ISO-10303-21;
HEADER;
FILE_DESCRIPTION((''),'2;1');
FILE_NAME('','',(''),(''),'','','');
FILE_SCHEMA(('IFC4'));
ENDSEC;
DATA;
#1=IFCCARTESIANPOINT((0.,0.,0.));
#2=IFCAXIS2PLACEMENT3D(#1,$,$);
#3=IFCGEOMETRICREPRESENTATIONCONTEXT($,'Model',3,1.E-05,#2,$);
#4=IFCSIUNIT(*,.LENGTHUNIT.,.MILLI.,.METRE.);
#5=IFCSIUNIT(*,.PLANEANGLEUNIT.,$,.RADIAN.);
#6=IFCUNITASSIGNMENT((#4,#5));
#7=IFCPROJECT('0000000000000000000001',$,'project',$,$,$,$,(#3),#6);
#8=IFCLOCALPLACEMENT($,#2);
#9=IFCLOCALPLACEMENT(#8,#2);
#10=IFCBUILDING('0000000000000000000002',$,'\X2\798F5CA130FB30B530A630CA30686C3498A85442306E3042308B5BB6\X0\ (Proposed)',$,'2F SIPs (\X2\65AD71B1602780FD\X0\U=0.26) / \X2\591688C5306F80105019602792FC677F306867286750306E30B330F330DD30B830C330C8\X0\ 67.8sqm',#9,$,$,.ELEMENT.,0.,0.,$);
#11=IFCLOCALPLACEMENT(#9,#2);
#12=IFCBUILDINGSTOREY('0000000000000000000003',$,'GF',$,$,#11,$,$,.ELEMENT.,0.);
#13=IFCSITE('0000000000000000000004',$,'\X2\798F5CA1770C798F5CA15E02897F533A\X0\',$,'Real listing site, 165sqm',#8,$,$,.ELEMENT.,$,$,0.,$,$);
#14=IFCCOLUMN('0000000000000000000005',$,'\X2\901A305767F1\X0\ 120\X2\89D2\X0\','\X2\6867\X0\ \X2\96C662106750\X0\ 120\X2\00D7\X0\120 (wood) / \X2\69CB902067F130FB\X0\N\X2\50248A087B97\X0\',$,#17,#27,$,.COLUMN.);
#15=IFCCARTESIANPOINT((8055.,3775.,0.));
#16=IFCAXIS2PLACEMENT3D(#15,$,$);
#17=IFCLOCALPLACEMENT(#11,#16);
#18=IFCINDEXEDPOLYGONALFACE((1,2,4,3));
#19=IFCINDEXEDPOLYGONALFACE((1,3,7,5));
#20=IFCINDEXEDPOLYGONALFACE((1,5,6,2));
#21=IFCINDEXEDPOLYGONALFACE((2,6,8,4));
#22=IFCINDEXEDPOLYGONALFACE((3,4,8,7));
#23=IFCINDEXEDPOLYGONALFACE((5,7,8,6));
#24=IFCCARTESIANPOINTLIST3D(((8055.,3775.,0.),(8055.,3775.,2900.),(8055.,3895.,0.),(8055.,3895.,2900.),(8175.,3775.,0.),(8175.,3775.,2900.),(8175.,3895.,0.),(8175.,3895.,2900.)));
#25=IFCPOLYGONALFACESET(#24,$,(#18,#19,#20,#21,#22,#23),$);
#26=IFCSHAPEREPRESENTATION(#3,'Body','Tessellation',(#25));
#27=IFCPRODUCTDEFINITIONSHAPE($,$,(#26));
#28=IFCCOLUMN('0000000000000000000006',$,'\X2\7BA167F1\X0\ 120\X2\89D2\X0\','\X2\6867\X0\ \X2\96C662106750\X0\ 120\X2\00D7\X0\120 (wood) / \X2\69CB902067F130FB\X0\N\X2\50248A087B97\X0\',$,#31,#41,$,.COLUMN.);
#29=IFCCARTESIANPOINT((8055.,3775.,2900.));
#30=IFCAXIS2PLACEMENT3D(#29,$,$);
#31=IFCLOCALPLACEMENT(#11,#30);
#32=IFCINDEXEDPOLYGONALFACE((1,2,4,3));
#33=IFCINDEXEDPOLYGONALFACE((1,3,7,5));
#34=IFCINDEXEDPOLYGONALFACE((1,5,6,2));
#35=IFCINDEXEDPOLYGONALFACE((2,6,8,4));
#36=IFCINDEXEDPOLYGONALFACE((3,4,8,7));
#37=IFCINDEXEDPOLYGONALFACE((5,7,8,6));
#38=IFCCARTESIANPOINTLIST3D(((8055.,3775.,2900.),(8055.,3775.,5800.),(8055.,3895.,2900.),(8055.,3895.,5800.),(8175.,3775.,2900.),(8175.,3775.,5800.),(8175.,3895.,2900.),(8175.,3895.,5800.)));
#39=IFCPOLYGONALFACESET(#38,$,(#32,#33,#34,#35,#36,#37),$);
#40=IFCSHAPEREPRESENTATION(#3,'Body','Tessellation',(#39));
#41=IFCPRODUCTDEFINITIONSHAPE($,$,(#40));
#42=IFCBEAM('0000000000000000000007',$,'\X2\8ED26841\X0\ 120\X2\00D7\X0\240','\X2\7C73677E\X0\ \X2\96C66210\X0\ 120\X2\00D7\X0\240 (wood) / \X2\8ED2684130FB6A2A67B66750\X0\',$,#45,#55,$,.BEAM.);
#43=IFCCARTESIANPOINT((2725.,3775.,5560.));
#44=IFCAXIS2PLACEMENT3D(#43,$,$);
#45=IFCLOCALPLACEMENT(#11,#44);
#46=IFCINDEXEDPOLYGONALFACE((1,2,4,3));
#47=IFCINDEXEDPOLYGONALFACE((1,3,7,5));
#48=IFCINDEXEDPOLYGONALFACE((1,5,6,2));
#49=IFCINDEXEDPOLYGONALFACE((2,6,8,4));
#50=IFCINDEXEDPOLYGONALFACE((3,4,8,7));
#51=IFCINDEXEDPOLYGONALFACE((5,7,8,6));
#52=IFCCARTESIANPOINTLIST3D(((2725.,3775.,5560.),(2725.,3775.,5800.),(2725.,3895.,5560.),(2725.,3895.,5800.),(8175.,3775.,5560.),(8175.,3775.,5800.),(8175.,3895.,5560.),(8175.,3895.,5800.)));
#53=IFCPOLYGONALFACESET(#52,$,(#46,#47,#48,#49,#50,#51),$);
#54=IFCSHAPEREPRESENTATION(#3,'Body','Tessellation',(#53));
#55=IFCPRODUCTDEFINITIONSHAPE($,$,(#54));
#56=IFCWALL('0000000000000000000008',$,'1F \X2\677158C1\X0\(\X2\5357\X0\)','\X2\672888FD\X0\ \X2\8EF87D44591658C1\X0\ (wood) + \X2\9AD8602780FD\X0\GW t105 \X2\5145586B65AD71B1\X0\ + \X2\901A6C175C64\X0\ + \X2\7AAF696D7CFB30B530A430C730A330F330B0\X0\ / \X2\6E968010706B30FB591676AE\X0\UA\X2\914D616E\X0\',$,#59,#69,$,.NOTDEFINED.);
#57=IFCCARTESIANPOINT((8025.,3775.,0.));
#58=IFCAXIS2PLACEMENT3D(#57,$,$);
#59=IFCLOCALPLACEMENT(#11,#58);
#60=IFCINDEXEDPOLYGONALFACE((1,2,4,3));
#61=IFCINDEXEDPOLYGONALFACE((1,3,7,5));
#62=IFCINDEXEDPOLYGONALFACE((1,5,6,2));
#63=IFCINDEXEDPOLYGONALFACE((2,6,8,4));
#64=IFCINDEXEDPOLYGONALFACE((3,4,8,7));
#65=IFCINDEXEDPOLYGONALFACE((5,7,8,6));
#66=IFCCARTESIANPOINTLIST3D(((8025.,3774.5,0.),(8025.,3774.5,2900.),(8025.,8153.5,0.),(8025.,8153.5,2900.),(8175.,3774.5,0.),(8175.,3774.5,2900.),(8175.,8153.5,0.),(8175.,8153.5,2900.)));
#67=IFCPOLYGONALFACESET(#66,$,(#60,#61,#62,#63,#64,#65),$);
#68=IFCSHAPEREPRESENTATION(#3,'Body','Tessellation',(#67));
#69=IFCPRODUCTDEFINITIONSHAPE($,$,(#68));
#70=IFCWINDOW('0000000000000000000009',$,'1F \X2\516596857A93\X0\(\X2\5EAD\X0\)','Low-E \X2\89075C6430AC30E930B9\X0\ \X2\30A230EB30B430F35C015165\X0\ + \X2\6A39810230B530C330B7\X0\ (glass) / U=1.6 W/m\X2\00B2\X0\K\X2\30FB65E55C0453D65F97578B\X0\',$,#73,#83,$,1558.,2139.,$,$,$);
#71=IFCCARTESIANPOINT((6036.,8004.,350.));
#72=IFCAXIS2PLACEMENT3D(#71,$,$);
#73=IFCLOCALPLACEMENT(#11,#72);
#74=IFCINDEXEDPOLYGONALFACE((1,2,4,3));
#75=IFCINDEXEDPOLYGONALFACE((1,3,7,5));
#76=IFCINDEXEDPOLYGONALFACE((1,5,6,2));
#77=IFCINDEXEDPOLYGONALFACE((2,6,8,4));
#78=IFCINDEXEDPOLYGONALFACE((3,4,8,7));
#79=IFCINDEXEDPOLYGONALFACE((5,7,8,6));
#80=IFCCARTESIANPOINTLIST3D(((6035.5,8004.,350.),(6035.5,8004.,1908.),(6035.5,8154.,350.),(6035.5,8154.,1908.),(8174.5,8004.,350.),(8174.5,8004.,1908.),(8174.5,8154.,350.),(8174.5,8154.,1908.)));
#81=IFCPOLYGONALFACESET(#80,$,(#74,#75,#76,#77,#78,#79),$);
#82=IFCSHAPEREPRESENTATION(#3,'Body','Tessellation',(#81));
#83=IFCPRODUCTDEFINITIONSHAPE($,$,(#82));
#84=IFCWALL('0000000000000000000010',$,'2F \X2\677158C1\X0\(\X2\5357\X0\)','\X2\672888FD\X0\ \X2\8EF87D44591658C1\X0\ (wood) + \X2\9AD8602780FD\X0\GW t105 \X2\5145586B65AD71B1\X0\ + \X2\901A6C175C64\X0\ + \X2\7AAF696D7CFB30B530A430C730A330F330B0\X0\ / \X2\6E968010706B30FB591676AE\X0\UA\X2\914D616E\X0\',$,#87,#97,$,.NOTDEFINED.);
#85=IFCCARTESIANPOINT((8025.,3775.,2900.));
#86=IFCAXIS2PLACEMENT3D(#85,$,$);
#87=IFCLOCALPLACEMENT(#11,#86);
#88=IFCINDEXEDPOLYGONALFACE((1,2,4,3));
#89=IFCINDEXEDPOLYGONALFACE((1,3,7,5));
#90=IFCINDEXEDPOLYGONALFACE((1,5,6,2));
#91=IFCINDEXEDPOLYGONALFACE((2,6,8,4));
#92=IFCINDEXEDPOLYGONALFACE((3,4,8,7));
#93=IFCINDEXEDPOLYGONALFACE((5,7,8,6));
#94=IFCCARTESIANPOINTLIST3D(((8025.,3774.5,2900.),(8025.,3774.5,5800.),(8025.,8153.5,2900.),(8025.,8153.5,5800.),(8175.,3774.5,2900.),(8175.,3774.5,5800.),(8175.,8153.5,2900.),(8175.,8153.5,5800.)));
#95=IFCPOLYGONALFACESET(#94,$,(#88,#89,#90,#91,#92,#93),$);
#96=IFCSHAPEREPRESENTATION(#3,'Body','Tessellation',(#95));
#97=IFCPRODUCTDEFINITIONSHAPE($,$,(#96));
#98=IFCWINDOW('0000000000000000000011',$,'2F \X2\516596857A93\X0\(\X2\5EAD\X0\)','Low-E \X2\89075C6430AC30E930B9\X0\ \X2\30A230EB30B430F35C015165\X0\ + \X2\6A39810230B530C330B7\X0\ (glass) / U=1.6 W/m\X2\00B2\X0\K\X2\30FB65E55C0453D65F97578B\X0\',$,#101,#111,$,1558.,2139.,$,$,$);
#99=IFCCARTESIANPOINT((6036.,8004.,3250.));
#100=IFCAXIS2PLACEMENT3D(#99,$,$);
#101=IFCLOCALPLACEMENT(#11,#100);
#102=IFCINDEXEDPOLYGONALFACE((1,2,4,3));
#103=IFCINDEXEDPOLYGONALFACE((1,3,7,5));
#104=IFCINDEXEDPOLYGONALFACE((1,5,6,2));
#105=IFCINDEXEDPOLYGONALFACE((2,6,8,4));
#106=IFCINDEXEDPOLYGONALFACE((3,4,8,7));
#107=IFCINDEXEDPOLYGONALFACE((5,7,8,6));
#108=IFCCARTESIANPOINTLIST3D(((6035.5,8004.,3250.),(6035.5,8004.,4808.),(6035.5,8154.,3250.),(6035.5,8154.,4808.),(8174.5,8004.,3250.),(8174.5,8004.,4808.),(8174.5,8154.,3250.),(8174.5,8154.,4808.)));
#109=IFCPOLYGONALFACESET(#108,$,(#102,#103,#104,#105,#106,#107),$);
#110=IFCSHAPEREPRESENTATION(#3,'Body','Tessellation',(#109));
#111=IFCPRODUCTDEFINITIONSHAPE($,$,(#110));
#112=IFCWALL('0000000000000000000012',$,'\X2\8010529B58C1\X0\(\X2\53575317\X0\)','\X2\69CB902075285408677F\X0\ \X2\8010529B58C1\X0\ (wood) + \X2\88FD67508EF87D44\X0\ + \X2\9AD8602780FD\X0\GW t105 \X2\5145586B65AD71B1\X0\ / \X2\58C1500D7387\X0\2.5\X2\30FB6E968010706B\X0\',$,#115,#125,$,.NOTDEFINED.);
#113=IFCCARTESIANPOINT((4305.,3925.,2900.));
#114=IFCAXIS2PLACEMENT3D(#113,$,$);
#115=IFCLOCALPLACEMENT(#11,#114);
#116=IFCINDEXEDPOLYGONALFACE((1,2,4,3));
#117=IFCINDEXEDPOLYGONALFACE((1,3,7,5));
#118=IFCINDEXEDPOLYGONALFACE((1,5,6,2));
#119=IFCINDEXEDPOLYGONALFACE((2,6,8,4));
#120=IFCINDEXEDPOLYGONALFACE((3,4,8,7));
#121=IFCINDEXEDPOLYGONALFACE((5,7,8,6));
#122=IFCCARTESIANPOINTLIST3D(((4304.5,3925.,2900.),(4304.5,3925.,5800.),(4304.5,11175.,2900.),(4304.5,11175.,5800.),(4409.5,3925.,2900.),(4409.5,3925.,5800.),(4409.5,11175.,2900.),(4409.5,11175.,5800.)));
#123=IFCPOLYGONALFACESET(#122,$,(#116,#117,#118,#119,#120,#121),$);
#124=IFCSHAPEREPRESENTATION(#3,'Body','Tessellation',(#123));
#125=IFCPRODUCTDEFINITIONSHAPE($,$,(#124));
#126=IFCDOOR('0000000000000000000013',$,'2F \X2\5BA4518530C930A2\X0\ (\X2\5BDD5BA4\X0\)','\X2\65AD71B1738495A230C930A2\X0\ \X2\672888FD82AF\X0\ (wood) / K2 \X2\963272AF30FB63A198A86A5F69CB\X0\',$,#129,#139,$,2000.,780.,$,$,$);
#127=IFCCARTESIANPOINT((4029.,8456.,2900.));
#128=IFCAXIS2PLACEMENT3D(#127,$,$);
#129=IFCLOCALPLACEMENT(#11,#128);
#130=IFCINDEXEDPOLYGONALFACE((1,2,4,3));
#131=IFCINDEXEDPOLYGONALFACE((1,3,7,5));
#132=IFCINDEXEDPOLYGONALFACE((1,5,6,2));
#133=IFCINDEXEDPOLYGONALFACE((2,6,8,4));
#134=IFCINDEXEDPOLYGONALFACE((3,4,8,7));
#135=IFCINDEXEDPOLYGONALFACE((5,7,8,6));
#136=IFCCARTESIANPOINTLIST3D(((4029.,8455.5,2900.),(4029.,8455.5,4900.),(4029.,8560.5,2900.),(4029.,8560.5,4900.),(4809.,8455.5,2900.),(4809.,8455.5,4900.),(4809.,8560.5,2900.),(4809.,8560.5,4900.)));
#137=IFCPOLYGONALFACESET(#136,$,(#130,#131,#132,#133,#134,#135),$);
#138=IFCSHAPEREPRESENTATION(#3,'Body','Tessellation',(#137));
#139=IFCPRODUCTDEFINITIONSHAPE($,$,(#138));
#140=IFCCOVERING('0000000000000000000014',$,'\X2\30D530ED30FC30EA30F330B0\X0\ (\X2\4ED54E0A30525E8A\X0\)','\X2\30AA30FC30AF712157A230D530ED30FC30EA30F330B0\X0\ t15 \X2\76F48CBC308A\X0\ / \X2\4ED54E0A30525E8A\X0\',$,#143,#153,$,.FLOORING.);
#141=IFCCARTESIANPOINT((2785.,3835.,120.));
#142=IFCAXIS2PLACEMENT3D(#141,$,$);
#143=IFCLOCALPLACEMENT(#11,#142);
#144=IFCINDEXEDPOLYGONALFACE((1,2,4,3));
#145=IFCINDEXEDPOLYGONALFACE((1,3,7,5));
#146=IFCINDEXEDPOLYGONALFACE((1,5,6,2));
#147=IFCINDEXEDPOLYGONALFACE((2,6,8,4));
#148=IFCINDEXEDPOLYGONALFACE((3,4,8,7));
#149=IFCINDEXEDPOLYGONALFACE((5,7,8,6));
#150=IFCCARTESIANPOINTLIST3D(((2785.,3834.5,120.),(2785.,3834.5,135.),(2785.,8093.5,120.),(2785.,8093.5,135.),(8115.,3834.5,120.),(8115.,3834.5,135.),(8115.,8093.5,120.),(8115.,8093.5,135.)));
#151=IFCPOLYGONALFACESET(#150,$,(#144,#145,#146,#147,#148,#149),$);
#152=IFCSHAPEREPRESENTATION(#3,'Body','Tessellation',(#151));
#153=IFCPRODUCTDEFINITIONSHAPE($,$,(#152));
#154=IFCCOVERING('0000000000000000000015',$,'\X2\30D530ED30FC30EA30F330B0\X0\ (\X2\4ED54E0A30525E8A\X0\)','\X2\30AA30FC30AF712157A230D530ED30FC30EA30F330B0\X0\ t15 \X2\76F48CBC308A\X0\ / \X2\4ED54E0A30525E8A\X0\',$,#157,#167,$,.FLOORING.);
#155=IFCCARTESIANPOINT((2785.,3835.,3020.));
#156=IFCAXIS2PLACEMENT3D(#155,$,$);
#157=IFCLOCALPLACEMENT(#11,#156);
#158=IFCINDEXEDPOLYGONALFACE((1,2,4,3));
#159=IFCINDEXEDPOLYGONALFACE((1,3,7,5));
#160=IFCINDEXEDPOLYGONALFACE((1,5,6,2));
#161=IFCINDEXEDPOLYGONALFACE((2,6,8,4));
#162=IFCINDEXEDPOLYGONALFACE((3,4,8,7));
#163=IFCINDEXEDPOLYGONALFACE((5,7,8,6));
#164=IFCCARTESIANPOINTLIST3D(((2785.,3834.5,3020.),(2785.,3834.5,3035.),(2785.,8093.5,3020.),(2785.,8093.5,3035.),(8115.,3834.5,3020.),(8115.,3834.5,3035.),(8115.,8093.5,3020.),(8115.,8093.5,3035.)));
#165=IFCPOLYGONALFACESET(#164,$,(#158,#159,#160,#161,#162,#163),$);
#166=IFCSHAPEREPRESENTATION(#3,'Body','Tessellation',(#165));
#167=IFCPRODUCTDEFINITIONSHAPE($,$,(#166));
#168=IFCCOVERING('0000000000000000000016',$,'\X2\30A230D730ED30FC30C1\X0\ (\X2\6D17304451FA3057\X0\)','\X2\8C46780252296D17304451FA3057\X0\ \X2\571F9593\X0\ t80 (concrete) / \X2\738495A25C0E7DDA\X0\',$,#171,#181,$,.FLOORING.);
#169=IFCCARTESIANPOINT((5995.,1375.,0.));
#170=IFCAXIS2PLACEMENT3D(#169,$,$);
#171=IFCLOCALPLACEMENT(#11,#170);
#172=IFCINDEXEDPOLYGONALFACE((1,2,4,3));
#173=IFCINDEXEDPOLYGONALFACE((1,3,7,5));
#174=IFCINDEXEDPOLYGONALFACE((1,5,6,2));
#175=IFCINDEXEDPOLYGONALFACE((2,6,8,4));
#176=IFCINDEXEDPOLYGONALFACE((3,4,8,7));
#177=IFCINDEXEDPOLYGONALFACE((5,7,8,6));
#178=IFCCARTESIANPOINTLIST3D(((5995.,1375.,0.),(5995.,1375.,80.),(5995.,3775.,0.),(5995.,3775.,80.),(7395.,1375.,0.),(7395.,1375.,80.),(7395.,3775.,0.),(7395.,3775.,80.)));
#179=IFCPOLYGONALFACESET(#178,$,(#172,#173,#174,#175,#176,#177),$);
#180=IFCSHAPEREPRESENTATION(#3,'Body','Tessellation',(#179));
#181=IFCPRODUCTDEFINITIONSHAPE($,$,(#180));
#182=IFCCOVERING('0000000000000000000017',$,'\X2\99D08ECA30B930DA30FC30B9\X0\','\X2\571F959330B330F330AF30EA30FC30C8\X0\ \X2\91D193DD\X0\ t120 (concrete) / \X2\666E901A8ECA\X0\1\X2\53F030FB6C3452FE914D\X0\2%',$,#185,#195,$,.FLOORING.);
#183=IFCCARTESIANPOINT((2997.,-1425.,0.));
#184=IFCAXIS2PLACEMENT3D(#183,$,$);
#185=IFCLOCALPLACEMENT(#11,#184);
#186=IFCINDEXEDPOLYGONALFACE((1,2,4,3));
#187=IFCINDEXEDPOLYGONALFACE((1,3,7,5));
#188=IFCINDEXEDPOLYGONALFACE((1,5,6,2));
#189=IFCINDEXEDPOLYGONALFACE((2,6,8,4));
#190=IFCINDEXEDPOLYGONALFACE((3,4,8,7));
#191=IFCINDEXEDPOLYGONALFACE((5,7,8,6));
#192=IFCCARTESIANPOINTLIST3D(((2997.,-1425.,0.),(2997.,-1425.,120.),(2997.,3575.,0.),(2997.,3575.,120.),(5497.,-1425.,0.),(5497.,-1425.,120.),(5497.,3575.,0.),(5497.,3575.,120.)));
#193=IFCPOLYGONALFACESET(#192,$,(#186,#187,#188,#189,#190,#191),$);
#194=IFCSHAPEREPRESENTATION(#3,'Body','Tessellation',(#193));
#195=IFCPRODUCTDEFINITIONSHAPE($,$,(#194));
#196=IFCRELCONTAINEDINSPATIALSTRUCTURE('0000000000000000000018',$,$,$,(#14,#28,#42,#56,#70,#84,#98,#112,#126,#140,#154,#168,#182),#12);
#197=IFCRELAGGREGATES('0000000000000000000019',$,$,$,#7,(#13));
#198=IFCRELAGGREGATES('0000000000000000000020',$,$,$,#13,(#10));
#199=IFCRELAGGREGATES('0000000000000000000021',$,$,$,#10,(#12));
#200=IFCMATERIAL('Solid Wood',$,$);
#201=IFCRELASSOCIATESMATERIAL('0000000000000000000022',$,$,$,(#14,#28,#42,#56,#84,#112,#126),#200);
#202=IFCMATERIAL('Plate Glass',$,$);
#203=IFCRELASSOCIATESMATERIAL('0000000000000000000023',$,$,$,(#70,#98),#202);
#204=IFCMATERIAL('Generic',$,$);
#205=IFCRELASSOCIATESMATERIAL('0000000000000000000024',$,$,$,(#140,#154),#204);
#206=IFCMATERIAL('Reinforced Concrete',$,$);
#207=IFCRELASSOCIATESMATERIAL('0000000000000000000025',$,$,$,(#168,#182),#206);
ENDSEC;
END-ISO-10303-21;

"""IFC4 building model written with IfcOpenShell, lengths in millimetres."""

from ifc_helpers import new_model, si_unit, frame, frame_2d, origin, place, context, project, spatial, rectangle, extrude, material, element, fill, save


model = new_model("IFC4")

# Units and contexts
model_context = context("Model", 3, precision=1e-05, world=origin())
ifc_project = project(units=[si_unit("LENGTHUNIT", "METRE", prefix="MILLI"), si_unit("PLANEANGLEUNIT", "RADIAN")], contexts=[model_context])

# Site, building, storey
site_placement = place(None, origin())
site = spatial("IfcSite", under=ifc_project, at=site_placement, Name="福岡県福岡市西区", ObjectType="Real listing site, 165sqm", CompositionType="ELEMENT", RefElevation=0.0)
building_placement = place(site_placement, origin())
building = spatial("IfcBuilding", under=site, at=building_placement, Name="福岡・サウナと水風呂のある家 (Proposed)", ObjectType="2F SIPs (断熱性能U=0.26) / 外装は耐候性鋼板と木材のコンポジット 67.8sqm", CompositionType="ELEMENT", ElevationOfRefHeight=0.0, ElevationOfTerrain=0.0)
storey_placement = place(building_placement, origin())
storey = spatial("IfcBuildingStorey", under=building, at=storey_placement, Name="GF", CompositionType="ELEMENT", Elevation=0.0)

# Columns
ifc_material_1 = material(Name="Solid Wood")
column_1_placement = place(storey_placement, frame((8055.0, 3775.0, 0.0)))
element("IfcColumn", 1, at=column_1_placement, inside=storey, material=ifc_material_1, Name="通し柱 120角", Description="桧 集成材 120×120 (wood) / 構造柱・N値計算", PredefinedType="COLUMN", context=model_context, shape_type="SweptSolid", body=[
    extrude(rectangle(XDim=120.0, YDim=120.0, at=frame_2d((60.0, 60.0))), frame((8055.0, 3775.0, 0.0)), (0.0, 0.0, 1.0), 2900.0),
])
column_2_placement = place(storey_placement, frame((8055.0, 3775.0, 2900.0)))
element("IfcColumn", 2, at=column_2_placement, inside=storey, material=ifc_material_1, Name="管柱 120角", Description="桧 集成材 120×120 (wood) / 構造柱・N値計算", PredefinedType="COLUMN", context=model_context, shape_type="SweptSolid", body=[
    extrude(rectangle(XDim=120.0, YDim=120.0, at=frame_2d((60.0, 60.0))), frame((8055.0, 3775.0, 2900.0)), (0.0, 0.0, 1.0), 2900.0),
])

# Beam
beam_1_placement = place(storey_placement, frame((2725.0, 3775.0, 5560.0)))
element("IfcBeam", 3, at=beam_1_placement, inside=storey, material=ifc_material_1, Name="軒桁 120×240", Description="米松 集成 120×240 (wood) / 軒桁・横架材", PredefinedType="BEAM", context=model_context, shape_type="SweptSolid", body=[
    extrude(rectangle(XDim=5450.0, YDim=120.0, at=frame_2d((2725.0, 60.0))), frame((2725.0, 3775.0, 5560.0)), (0.0, 0.0, 1.0), 240.0),
])

# Wall, opening, window
wall_1_placement = place(storey_placement, frame((8025.0, 3775.0, 0.0)))
wall_1 = element("IfcWall", 4, at=wall_1_placement, inside=storey, material=ifc_material_1, Name="1F 東壁(南)", Description="木製 軸組外壁 (wood) + 高性能GW t105 充填断熱 + 通気層 + 窯業系サイディング / 準耐火・外皮UA配慮", PredefinedType="NOTDEFINED", context=model_context, shape_type="SweptSolid", body=[
    extrude(rectangle(XDim=150.0, YDim=4379.0, at=frame_2d((75.0, 2189.0))), frame((8025.0, 3775.0, 0.0)), (0.0, 0.0, 1.0), 2900.0),
])
opening_1_placement = place(storey_placement, frame((6036.0, 8004.0, 350.0)))
opening_1 = element("IfcOpeningElement", 5, at=opening_1_placement, cuts=wall_1, PredefinedType="NOTDEFINED", context=model_context, shape_type="SweptSolid", body=[
    extrude(rectangle(XDim=2139.0, YDim=150.0, at=frame_2d((1069.0, 75.0))), frame((6036.0, 8004.0, 350.0)), (0.0, 0.0, 1.0), 1558.0),
])
ifc_material_2 = material(Name="Plate Glass")
window_1_placement = place(storey_placement, frame((6036.0, 8004.0, 350.0)))
window_1 = element("IfcWindow", 6, at=window_1_placement, inside=storey, material=ifc_material_2, Name="1F 入隅窓(庭)", Description="Low-E 複層ガラス アルゴン封入 + 樹脂サッシ (glass) / U=1.6 W/m²K・日射取得型", OverallHeight=1558.0, OverallWidth=2139.0, context=model_context, shape_type="SweptSolid", body=[
    extrude(rectangle(XDim=2139.0, YDim=150.0, at=frame_2d((1069.0, 75.0))), frame((6036.0, 8004.0, 350.0)), (0.0, 0.0, 1.0), 1558.0),
])
fill(opening_1, window_1)

# Wall, opening, window
wall_2_placement = place(storey_placement, frame((8025.0, 3775.0, 2900.0)))
wall_2 = element("IfcWall", 7, at=wall_2_placement, inside=storey, material=ifc_material_1, Name="2F 東壁(南)", Description="木製 軸組外壁 (wood) + 高性能GW t105 充填断熱 + 通気層 + 窯業系サイディング / 準耐火・外皮UA配慮", PredefinedType="NOTDEFINED", context=model_context, shape_type="SweptSolid", body=[
    extrude(rectangle(XDim=150.0, YDim=4379.0, at=frame_2d((75.0, 2189.0))), frame((8025.0, 3775.0, 2900.0)), (0.0, 0.0, 1.0), 2900.0),
])
opening_2_placement = place(storey_placement, frame((6036.0, 8004.0, 3250.0)))
opening_2 = element("IfcOpeningElement", 8, at=opening_2_placement, cuts=wall_2, PredefinedType="NOTDEFINED", context=model_context, shape_type="SweptSolid", body=[
    extrude(rectangle(XDim=2139.0, YDim=150.0, at=frame_2d((1069.0, 75.0))), frame((6036.0, 8004.0, 3250.0)), (0.0, 0.0, 1.0), 1558.0),
])
window_2_placement = place(storey_placement, frame((6036.0, 8004.0, 3250.0)))
window_2 = element("IfcWindow", 9, at=window_2_placement, inside=storey, material=ifc_material_2, Name="2F 入隅窓(庭)", Description="Low-E 複層ガラス アルゴン封入 + 樹脂サッシ (glass) / U=1.6 W/m²K・日射取得型", OverallHeight=1558.0, OverallWidth=2139.0, context=model_context, shape_type="SweptSolid", body=[
    extrude(rectangle(XDim=2139.0, YDim=150.0, at=frame_2d((1069.0, 75.0))), frame((6036.0, 8004.0, 3250.0)), (0.0, 0.0, 1.0), 1558.0),
])
fill(opening_2, window_2)

# Wall, opening, door
wall_3_placement = place(storey_placement, frame((4305.0, 3925.0, 2900.0)))
wall_3 = element("IfcWall", 10, at=wall_3_placement, inside=storey, material=ifc_material_1, Name="耐力壁(南北)", Description="構造用合板 耐力壁 (wood) + 製材軸組 + 高性能GW t105 充填断熱 / 壁倍率2.5・準耐火", PredefinedType="NOTDEFINED", context=model_context, shape_type="SweptSolid", body=[
    extrude(rectangle(XDim=105.0, YDim=7250.0, at=frame_2d((52.0, 3625.0))), frame((4305.0, 3925.0, 2900.0)), (0.0, 0.0, 1.0), 2900.0),
])
opening_3_placement = place(storey_placement, frame((4029.0, 8456.0, 2900.0)))
opening_3 = element("IfcOpeningElement", 11, at=opening_3_placement, cuts=wall_3, PredefinedType="NOTDEFINED", context=model_context, shape_type="SweptSolid", body=[
    extrude(rectangle(XDim=780.0, YDim=105.0, at=frame_2d((390.0, 52.0))), frame((4029.0, 8456.0, 2900.0)), (0.0, 0.0, 1.0), 2000.0),
])
door_1_placement = place(storey_placement, frame((4029.0, 8456.0, 2900.0)))
door_1 = element("IfcDoor", 12, at=door_1_placement, inside=storey, material=ifc_material_1, Name="2F 室内ドア (寝室)", Description="断熱玄関ドア 木製芯 (wood) / K2 防犯・採風機構", OverallHeight=2000.0, OverallWidth=780.0, context=model_context, shape_type="SweptSolid", body=[
    extrude(rectangle(XDim=780.0, YDim=105.0, at=frame_2d((390.0, 52.0))), frame((4029.0, 8456.0, 2900.0)), (0.0, 0.0, 1.0), 2000.0),
])
fill(opening_3, door_1)

# Coverings
ifc_material_3 = material(Name="Generic")
covering_1_placement = place(storey_placement, frame((2785.0, 3835.0, 120.0)))
element("IfcCovering", 13, at=covering_1_placement, inside=storey, material=ifc_material_3, Name="フローリング (仕上げ床)", Description="オーク無垢フローリング t15 直貼り / 仕上げ床", PredefinedType="FLOORING", context=model_context, shape_type="SweptSolid", body=[
    extrude(rectangle(XDim=5330.0, YDim=4259.0, at=frame_2d((2665.0, 2129.0))), frame((2785.0, 3835.0, 120.0)), (0.0, 0.0, 1.0), 15.0),
])
covering_2_placement = place(storey_placement, frame((2785.0, 3835.0, 3020.0)))
element("IfcCovering", 14, at=covering_2_placement, inside=storey, material=ifc_material_3, Name="フローリング (仕上げ床)", Description="オーク無垢フローリング t15 直貼り / 仕上げ床", PredefinedType="FLOORING", context=model_context, shape_type="SweptSolid", body=[
    extrude(rectangle(XDim=5330.0, YDim=4259.0, at=frame_2d((2665.0, 2129.0))), frame((2785.0, 3835.0, 3020.0)), (0.0, 0.0, 1.0), 15.0),
])
ifc_material_4 = material(Name="Reinforced Concrete")
covering_3_placement = place(storey_placement, frame((5995.0, 1375.0, 0.0)))
element("IfcCovering", 15, at=covering_3_placement, inside=storey, material=ifc_material_4, Name="アプローチ (洗い出し)", Description="豆砂利洗い出し 土間 t80 (concrete) / 玄関導線", PredefinedType="FLOORING", context=model_context, shape_type="SweptSolid", body=[
    extrude(rectangle(XDim=1400.0, YDim=2400.0, at=frame_2d((700.0, 1200.0))), frame((5995.0, 1375.0, 0.0)), (0.0, 0.0, 1.0), 80.0),
])
covering_4_placement = place(storey_placement, frame((2997.0, -1425.0, 0.0)))
element("IfcCovering", 16, at=covering_4_placement, inside=storey, material=ifc_material_4, Name="駐車スペース", Description="土間コンクリート 金鏝 t120 (concrete) / 普通車1台・水勾配2%", PredefinedType="FLOORING", context=model_context, shape_type="SweptSolid", body=[
    extrude(rectangle(XDim=2500.0, YDim=5000.0, at=frame_2d((1250.0, 2500.0))), frame((2997.0, -1425.0, 0.0)), (0.0, 0.0, 1.0), 120.0),
])

save(model, "model.ifc")
